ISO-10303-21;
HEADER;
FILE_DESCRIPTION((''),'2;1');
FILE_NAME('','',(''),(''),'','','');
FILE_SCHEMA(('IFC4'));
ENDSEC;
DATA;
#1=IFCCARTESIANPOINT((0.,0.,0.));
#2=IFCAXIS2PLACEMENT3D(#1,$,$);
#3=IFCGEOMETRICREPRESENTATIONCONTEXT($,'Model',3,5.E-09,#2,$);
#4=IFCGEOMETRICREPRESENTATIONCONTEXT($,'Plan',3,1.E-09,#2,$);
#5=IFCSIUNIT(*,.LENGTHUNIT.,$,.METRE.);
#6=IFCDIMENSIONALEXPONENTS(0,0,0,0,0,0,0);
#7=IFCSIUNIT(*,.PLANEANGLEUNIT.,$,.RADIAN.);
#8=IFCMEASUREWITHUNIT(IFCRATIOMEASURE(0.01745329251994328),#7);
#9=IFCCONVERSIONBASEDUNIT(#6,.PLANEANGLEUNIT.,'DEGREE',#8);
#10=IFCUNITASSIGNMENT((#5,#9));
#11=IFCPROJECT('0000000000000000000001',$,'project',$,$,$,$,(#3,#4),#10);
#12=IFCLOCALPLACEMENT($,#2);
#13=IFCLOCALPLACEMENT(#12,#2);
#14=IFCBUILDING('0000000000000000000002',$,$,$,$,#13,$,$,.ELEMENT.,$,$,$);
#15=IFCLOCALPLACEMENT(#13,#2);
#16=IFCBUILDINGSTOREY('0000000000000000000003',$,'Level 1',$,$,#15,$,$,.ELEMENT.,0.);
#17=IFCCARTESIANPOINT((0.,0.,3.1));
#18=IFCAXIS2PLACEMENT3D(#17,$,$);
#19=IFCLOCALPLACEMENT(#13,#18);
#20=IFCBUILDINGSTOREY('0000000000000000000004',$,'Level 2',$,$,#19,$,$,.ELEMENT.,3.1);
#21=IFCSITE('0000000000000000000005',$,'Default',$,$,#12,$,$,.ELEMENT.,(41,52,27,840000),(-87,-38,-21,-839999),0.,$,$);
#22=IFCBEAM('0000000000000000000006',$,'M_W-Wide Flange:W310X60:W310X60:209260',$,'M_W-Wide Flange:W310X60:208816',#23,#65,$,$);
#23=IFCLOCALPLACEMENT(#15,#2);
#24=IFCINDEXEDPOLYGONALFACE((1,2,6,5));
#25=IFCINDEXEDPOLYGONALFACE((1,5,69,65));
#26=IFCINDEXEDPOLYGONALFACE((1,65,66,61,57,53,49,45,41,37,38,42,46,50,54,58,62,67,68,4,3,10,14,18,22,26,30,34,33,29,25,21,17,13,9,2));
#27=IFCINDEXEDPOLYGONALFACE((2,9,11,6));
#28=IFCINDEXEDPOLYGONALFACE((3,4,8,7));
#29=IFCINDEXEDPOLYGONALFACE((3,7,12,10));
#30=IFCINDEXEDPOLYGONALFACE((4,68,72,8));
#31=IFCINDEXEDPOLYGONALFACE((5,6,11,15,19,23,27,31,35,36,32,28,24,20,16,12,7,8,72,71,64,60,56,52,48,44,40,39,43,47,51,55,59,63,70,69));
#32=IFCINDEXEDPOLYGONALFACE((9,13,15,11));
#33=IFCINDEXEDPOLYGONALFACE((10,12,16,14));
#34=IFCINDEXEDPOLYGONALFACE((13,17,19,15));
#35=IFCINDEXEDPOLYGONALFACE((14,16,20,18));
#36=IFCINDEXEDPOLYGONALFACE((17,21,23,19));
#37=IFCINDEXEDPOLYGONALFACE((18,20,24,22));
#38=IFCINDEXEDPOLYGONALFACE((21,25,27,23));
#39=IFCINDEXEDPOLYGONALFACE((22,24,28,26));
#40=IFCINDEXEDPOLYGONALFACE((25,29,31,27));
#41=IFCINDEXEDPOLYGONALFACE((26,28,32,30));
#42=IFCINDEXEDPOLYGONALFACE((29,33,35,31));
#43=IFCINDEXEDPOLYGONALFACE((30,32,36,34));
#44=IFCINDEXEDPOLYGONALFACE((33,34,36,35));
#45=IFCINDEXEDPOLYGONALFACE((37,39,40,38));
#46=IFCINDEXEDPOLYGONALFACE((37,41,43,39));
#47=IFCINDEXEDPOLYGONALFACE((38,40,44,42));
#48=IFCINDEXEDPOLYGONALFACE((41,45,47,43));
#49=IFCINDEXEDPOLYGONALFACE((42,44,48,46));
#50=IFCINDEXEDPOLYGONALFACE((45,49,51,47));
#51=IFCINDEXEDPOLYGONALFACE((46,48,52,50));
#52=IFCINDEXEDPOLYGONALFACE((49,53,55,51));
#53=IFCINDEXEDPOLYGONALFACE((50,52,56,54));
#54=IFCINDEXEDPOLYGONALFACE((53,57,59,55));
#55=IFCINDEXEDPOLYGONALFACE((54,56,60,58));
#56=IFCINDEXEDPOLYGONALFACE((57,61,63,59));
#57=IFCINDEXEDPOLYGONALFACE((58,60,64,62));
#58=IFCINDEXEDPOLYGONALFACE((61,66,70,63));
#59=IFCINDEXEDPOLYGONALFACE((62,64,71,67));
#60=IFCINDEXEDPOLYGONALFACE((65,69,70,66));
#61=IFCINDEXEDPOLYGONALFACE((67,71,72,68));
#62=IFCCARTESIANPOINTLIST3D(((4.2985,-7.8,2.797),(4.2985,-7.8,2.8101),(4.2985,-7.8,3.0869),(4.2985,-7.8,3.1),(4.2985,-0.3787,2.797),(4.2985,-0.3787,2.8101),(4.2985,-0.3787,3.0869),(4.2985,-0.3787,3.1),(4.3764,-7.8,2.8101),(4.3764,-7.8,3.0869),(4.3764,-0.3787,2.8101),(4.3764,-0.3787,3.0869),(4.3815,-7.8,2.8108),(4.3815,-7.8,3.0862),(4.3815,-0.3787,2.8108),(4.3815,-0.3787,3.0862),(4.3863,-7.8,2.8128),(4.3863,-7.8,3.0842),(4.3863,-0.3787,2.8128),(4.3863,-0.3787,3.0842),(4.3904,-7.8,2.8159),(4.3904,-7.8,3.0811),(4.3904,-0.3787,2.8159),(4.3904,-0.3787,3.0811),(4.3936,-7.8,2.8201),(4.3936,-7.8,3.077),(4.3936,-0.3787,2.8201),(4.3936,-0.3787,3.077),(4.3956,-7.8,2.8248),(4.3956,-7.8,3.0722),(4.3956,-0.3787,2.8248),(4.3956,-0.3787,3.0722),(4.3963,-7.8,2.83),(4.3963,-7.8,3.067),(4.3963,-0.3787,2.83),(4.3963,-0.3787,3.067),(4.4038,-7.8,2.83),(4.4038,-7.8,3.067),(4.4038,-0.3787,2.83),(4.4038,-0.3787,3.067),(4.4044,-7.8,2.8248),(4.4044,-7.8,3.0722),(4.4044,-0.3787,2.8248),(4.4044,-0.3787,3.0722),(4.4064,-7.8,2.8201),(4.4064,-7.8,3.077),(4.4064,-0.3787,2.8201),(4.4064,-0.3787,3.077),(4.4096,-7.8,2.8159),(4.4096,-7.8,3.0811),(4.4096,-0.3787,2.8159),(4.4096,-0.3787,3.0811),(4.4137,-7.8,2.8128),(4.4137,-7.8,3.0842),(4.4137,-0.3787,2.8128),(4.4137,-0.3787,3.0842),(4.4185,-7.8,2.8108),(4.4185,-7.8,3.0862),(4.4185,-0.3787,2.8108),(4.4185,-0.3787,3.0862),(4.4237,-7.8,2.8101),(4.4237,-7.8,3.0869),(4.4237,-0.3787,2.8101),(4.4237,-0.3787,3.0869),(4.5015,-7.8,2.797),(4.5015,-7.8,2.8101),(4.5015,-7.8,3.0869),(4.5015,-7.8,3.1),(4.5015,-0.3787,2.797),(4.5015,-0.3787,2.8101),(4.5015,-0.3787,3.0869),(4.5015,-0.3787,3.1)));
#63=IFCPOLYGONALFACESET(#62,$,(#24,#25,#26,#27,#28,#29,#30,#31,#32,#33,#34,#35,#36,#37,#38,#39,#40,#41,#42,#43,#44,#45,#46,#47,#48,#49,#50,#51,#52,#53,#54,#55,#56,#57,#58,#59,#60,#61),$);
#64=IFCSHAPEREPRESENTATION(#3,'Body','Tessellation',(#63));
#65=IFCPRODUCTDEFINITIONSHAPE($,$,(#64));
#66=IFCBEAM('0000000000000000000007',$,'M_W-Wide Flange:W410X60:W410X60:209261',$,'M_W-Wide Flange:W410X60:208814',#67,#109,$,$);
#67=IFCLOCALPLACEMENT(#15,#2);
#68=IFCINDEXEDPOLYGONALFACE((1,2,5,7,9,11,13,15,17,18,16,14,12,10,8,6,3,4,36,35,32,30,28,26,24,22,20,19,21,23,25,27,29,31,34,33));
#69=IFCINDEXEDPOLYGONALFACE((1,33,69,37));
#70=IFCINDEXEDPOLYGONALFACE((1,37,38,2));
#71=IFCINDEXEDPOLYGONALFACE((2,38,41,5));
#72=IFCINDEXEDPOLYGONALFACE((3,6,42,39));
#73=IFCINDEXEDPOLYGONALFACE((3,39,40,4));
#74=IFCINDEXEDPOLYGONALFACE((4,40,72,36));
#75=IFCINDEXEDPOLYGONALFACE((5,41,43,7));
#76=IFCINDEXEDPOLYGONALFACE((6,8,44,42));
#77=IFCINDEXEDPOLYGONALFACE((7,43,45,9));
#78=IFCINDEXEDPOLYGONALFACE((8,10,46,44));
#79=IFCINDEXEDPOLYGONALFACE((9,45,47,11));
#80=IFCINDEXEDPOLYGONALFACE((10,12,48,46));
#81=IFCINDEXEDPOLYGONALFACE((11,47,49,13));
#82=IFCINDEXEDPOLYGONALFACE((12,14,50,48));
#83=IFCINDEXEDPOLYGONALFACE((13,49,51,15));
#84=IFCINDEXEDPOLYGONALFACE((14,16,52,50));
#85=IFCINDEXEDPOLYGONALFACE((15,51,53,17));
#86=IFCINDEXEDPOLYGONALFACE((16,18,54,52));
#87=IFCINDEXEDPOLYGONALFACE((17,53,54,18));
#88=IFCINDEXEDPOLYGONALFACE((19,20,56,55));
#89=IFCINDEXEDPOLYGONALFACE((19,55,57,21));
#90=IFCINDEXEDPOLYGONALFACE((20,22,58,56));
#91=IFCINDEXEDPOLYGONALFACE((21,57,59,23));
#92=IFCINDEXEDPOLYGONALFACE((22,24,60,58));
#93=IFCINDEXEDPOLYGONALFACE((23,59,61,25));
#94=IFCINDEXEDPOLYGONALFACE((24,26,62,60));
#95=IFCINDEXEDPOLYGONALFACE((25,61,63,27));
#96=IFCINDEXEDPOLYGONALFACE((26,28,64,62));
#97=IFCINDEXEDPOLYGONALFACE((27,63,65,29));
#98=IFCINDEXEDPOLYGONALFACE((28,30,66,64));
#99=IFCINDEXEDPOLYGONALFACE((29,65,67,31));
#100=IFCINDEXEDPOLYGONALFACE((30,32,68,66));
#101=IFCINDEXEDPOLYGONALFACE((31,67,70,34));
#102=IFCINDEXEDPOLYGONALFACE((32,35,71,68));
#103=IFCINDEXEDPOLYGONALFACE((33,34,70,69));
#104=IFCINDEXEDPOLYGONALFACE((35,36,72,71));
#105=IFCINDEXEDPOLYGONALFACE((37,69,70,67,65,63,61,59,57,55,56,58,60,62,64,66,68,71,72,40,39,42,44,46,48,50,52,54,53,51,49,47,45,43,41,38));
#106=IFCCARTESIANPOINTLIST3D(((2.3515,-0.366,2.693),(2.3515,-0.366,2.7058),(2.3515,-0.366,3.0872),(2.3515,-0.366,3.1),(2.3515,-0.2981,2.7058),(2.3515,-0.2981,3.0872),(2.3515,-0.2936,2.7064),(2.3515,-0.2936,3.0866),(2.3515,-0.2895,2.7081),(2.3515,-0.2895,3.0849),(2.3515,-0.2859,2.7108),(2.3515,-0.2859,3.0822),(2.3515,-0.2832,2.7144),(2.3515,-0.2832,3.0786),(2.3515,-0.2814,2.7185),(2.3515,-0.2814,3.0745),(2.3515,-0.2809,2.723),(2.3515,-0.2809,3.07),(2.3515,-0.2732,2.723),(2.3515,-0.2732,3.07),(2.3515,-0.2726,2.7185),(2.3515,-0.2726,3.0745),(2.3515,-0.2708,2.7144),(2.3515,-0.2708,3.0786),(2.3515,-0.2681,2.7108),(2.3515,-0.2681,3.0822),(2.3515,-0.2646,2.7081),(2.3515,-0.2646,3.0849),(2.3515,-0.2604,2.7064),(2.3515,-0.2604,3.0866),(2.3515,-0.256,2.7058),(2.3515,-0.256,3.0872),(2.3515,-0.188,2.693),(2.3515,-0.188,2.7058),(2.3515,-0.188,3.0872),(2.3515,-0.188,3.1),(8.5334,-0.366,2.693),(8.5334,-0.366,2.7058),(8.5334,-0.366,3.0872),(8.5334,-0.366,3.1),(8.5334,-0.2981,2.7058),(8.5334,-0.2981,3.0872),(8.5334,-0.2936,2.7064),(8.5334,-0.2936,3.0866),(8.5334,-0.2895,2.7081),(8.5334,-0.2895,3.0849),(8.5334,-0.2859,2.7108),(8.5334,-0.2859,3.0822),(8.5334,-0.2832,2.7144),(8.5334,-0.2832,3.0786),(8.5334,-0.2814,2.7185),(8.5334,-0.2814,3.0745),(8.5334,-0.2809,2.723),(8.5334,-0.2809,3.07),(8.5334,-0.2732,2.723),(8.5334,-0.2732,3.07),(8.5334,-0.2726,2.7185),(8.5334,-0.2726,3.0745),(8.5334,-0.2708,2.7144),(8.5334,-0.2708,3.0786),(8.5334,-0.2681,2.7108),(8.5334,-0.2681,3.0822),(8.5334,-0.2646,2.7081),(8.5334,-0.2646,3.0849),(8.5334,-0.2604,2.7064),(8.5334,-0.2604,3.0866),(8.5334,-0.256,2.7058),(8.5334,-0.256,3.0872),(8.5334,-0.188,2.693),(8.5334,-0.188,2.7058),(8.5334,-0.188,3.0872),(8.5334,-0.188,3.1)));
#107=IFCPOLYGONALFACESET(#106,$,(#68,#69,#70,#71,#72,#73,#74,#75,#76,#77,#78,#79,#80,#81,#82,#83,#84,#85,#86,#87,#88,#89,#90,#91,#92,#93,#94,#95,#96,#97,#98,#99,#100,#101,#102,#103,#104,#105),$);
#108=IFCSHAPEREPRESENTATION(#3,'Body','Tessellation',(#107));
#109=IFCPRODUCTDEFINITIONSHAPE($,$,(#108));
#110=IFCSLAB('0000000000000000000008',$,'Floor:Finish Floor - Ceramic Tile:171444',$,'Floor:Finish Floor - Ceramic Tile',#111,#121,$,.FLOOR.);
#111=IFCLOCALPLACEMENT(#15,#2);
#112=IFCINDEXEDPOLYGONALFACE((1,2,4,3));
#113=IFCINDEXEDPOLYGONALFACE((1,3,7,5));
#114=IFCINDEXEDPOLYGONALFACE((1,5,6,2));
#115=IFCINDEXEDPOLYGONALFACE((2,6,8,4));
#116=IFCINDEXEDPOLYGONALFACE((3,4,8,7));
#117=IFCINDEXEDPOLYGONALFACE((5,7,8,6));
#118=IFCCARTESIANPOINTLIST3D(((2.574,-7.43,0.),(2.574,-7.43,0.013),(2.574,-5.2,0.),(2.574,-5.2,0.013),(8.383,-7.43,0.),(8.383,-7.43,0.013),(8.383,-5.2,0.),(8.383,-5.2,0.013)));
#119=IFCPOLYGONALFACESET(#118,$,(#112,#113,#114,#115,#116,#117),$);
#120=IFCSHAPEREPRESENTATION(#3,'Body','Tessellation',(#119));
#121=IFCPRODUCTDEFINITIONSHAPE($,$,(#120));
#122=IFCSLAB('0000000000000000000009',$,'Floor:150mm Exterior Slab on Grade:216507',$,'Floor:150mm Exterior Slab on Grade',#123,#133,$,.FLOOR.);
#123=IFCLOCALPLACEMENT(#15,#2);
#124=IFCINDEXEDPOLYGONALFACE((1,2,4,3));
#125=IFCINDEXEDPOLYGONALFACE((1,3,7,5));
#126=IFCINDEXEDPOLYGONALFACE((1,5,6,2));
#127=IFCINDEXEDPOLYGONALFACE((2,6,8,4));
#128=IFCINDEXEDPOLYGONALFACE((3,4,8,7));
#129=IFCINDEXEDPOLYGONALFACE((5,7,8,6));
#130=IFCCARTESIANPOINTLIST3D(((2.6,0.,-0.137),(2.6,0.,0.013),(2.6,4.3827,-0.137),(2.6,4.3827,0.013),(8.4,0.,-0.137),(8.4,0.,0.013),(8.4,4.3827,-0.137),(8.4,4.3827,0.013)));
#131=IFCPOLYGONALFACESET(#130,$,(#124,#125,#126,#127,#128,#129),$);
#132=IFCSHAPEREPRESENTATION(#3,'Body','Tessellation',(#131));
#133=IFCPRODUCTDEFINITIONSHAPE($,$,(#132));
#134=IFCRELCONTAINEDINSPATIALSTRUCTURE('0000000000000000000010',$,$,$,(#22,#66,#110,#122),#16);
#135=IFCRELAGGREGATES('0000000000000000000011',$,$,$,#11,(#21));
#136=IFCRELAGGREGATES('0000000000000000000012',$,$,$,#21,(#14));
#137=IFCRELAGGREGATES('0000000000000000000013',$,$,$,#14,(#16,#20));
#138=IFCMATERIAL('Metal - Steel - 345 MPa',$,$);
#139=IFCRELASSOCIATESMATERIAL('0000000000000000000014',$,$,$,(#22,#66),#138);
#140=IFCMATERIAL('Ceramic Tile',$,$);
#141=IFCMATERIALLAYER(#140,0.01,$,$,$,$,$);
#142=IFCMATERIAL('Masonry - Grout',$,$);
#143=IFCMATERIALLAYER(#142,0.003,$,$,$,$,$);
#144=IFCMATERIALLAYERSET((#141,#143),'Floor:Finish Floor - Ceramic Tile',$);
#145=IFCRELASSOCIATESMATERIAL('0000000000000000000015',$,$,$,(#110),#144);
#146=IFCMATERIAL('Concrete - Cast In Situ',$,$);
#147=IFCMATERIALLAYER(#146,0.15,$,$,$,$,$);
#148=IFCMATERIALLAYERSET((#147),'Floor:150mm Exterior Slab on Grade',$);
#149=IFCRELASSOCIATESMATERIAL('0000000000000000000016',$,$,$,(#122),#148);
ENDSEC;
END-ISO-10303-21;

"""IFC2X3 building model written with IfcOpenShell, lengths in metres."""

from ifc_helpers import new_model, entity, si_unit, converted_unit, frame, frame_2d, origin, place, context, project, spatial, polyline, circle_curve, parameter, trimmed, segment, composite_curve, rectangle, outline, extrude, material, layer, layer_set, layer_usage, element, save


model = new_model("IFC2X3")

# Units and contexts
model_context = context("Model", 3, precision=5e-09, world=origin())
plan_context = context("Plan", 3, precision=1e-09, world=origin())
ifc_project = project(units=[si_unit("LENGTHUNIT", "METRE"), converted_unit("PLANEANGLEUNIT", "DEGREE", entity("IfcRatioMeasure", 0.01745329251994328), si_unit("PLANEANGLEUNIT", "RADIAN"), dimensions=[0, 0, 0, 0, 0, 0, 0])], contexts=[model_context, plan_context])

# Site, building, storey
site_placement = place(None, origin())
site = spatial("IfcSite", under=ifc_project, at=site_placement, Name="Default", CompositionType="ELEMENT", RefLatitude=(41, 52, 27, 840000), RefLongitude=(-87, -38, -21, -839999), RefElevation=0.0)
building_placement = place(site_placement, origin())
building = spatial("IfcBuilding", under=site, at=building_placement, CompositionType="ELEMENT")
storey_1_placement = place(building_placement, origin())
storey_1 = spatial("IfcBuildingStorey", under=building, at=storey_1_placement, Name="Level 1", CompositionType="ELEMENT", Elevation=0.0)

# Beams
ifc_material_1 = material(Name="Metal - Steel - 345 MPa")
beam_1_placement = place(storey_1_placement, frame((4.4, -7.8, 3.1)))
element("IfcBeam", 1, at=beam_1_placement, inside=storey_1, material=ifc_material_1, Name="M_W-Wide Flange:W310X60:W310X60:209260", ObjectType="M_W-Wide Flange:W310X60:208816", context=model_context, shape_type="SweptSolid", body=[
    extrude(outline(composite_curve([segment(polyline([(-0.1015, -0.1384), (-0.1015, -0.1515)]), True, "CONTINUOUS"), segment(polyline([(-0.1015, -0.1515), (0.1015, -0.1515)]), True, "CONTINUOUS"), segment(polyline([(0.1015, -0.1515), (0.1015, -0.1384)]), True, "CONTINUOUS"), segment(polyline([(0.1015, -0.1384), (0.0236, -0.1384)]), True, "CONTINUOUS"), segment(trimmed(circle_curve(frame_2d((0.0236, -0.1185), x_axis=(1.0, 0.0)), 0.0199), [parameter(180.0)], [parameter(270.0)], True, "PARAMETER"), False, "CONTINUOUS"), segment(polyline([(0.0037, -0.1185), (0.0037, 0.1185)]), True, "CONTINUOUS"), segment(trimmed(circle_curve(frame_2d((0.0236, 0.1185), x_axis=(1.0, 0.0)), 0.0199), [parameter(90.0)], [parameter(180.0)], True, "PARAMETER"), False, "CONTINUOUS"), segment(polyline([(0.0236, 0.1384), (0.1015, 0.1384)]), True, "CONTINUOUS"), segment(polyline([(0.1015, 0.1384), (0.1015, 0.1515)]), True, "CONTINUOUS"), segment(polyline([(0.1015, 0.1515), (-0.1015, 0.1515)]), True, "CONTINUOUS"), segment(polyline([(-0.1015, 0.1515), (-0.1015, 0.1384)]), True, "CONTINUOUS"), segment(polyline([(-0.1015, 0.1384), (-0.0237, 0.1384)]), True, "CONTINUOUS"), segment(trimmed(circle_curve(frame_2d((-0.0237, 0.1185), x_axis=(1.0, 0.0)), 0.0199), [parameter(360.0)], [parameter(90.0)], True, "PARAMETER"), False, "CONTINUOUS"), segment(polyline([(-0.0038, 0.1185), (-0.0038, -0.1185)]), True, "CONTINUOUS"), segment(trimmed(circle_curve(frame_2d((-0.0237, -0.1185), x_axis=(1.0, 0.0)), 0.0199), [parameter(270.0)], [parameter(0.0)], True, "PARAMETER"), False, "CONTINUOUS"), segment(polyline([(-0.0237, -0.1384), (-0.1015, -0.1384)]), True, "CONTINUOUS")], self_intersect=False)), frame((0.0, 0.0, -0.1515), z_axis=(0.0, -1.0, 0.0), x_axis=(1.0, 0.0, 0.0)), (0.0, 0.0, -1.0), 7.4213),
])
beam_2_placement = place(storey_1_placement, frame((8.5915, -0.277, 3.1), z_axis=(0.0, 0.0, 1.0), x_axis=(0.0, 1.0, 0.0)))
element("IfcBeam", 2, at=beam_2_placement, inside=storey_1, material=ifc_material_1, Name="M_W-Wide Flange:W410X60:W410X60:209261", ObjectType="M_W-Wide Flange:W410X60:208814", context=model_context, shape_type="SweptSolid", body=[
    extrude(outline(composite_curve([segment(polyline([(0.1907, -0.089), (0.2035, -0.089)]), True, "CONTINUOUS"), segment(polyline([(0.2035, -0.089), (0.2035, 0.089)]), True, "CONTINUOUS"), segment(polyline([(0.2035, 0.089), (0.1907, 0.089)]), True, "CONTINUOUS"), segment(polyline([(0.1907, 0.089), (0.1907, 0.021)]), True, "CONTINUOUS"), segment(trimmed(circle_curve(frame_2d((0.1735, 0.021), x_axis=(1.0, 0.0)), 0.0172), [parameter(270.0)], [parameter(360.0)], True, "PARAMETER"), False, "CONTINUOUS"), segment(polyline([(0.1735, 0.0038), (-0.1735, 0.0038)]), True, "CONTINUOUS"), segment(trimmed(circle_curve(frame_2d((-0.1735, 0.021), x_axis=(0.0, -1.0)), 0.0172), [parameter(270.0)], [parameter(360.0)], True, "PARAMETER"), False, "CONTINUOUS"), segment(polyline([(-0.1907, 0.021), (-0.1907, 0.089)]), True, "CONTINUOUS"), segment(polyline([(-0.1907, 0.089), (-0.2035, 0.089)]), True, "CONTINUOUS"), segment(polyline([(-0.2035, 0.089), (-0.2035, -0.089)]), True, "CONTINUOUS"), segment(polyline([(-0.2035, -0.089), (-0.1907, -0.089)]), True, "CONTINUOUS"), segment(polyline([(-0.1907, -0.089), (-0.1907, -0.0211)]), True, "CONTINUOUS"), segment(trimmed(circle_curve(frame_2d((-0.1735, -0.0211), x_axis=(-1.0, 0.0)), 0.0172), [parameter(270.0)], [parameter(0.0)], True, "PARAMETER"), False, "CONTINUOUS"), segment(polyline([(-0.1735, -0.0039), (0.1735, -0.0039)]), True, "CONTINUOUS"), segment(trimmed(circle_curve(frame_2d((0.1735, -0.0211), x_axis=(0.0, 1.0)), 0.0172), [parameter(270.0)], [parameter(0.0)], True, "PARAMETER"), False, "CONTINUOUS"), segment(polyline([(0.1907, -0.0211), (0.1907, -0.089)]), True, "CONTINUOUS")], self_intersect=False)), frame((0.0, 6.24, -0.2035), z_axis=(0.0, -1.0, 0.0), x_axis=(0.0, 0.0, -1.0)), (0.0, 0.0, 1.0), 6.1819),
])

# Slabs
ifc_material_2 = material(Name="Ceramic Tile")
ifc_layer_1 = layer(ifc_material_2, 0.01)
ifc_material_3 = material(Name="Masonry - Grout")
ifc_layer_2 = layer(ifc_material_3, 0.003)
ifc_layer_set_1 = layer_set([ifc_layer_1, ifc_layer_2], Name="Floor:Finish Floor - Ceramic Tile")
ifc_layer_usage_1 = layer_usage(ifc_layer_set_1, "AXIS3", "POSITIVE", 0.0)
slab_1_placement = place(storey_1_placement, frame((2.574, -7.43, 0.0)))
element("IfcSlab", 3, at=slab_1_placement, inside=storey_1, material=ifc_layer_usage_1, Name="Floor:Finish Floor - Ceramic Tile:171444", ObjectType="Floor:Finish Floor - Ceramic Tile", PredefinedType="FLOOR", context=model_context, shape_type="SweptSolid", body=[
    extrude(rectangle(XDim=5.809, YDim=2.23, at=frame_2d((0.0, 0.0), x_axis=(-1.0, 0.0))), frame((2.9045, 1.115, 0.013), z_axis=(0.0, 0.0, -1.0), x_axis=(-1.0, 0.0, 0.0)), (0.0, 0.0, 1.0), 0.013),
])
ifc_material_4 = material(Name="Concrete - Cast In Situ")
ifc_layer_3 = layer(ifc_material_4, 0.15)
ifc_layer_set_2 = layer_set([ifc_layer_3], Name="Floor:150mm Exterior Slab on Grade")
ifc_layer_usage_2 = layer_usage(ifc_layer_set_2, "AXIS3", "POSITIVE", 0.0)
slab_2_placement = place(storey_1_placement, frame((2.6, 0.0, -0.137)))
element("IfcSlab", 4, at=slab_2_placement, inside=storey_1, material=ifc_layer_usage_2, Name="Floor:150mm Exterior Slab on Grade:216507", ObjectType="Floor:150mm Exterior Slab on Grade", PredefinedType="FLOOR", context=model_context, shape_type="SweptSolid", body=[
    extrude(rectangle(XDim=5.8, YDim=4.3827, at=frame_2d((0.0, 0.0), x_axis=(-1.0, 0.0))), frame((2.9, 2.1914, 0.15), z_axis=(0.0, 0.0, -1.0), x_axis=(-1.0, 0.0, 0.0)), (0.0, 0.0, 1.0), 0.15),
])

# Shared definitions
storey_2_placement = place(building_placement, frame((0.0, 0.0, 3.1)))
storey_2 = spatial("IfcBuildingStorey", under=building, at=storey_2_placement, Name="Level 2", CompositionType="ELEMENT", Elevation=3.1)

save(model, "model.ifc")
